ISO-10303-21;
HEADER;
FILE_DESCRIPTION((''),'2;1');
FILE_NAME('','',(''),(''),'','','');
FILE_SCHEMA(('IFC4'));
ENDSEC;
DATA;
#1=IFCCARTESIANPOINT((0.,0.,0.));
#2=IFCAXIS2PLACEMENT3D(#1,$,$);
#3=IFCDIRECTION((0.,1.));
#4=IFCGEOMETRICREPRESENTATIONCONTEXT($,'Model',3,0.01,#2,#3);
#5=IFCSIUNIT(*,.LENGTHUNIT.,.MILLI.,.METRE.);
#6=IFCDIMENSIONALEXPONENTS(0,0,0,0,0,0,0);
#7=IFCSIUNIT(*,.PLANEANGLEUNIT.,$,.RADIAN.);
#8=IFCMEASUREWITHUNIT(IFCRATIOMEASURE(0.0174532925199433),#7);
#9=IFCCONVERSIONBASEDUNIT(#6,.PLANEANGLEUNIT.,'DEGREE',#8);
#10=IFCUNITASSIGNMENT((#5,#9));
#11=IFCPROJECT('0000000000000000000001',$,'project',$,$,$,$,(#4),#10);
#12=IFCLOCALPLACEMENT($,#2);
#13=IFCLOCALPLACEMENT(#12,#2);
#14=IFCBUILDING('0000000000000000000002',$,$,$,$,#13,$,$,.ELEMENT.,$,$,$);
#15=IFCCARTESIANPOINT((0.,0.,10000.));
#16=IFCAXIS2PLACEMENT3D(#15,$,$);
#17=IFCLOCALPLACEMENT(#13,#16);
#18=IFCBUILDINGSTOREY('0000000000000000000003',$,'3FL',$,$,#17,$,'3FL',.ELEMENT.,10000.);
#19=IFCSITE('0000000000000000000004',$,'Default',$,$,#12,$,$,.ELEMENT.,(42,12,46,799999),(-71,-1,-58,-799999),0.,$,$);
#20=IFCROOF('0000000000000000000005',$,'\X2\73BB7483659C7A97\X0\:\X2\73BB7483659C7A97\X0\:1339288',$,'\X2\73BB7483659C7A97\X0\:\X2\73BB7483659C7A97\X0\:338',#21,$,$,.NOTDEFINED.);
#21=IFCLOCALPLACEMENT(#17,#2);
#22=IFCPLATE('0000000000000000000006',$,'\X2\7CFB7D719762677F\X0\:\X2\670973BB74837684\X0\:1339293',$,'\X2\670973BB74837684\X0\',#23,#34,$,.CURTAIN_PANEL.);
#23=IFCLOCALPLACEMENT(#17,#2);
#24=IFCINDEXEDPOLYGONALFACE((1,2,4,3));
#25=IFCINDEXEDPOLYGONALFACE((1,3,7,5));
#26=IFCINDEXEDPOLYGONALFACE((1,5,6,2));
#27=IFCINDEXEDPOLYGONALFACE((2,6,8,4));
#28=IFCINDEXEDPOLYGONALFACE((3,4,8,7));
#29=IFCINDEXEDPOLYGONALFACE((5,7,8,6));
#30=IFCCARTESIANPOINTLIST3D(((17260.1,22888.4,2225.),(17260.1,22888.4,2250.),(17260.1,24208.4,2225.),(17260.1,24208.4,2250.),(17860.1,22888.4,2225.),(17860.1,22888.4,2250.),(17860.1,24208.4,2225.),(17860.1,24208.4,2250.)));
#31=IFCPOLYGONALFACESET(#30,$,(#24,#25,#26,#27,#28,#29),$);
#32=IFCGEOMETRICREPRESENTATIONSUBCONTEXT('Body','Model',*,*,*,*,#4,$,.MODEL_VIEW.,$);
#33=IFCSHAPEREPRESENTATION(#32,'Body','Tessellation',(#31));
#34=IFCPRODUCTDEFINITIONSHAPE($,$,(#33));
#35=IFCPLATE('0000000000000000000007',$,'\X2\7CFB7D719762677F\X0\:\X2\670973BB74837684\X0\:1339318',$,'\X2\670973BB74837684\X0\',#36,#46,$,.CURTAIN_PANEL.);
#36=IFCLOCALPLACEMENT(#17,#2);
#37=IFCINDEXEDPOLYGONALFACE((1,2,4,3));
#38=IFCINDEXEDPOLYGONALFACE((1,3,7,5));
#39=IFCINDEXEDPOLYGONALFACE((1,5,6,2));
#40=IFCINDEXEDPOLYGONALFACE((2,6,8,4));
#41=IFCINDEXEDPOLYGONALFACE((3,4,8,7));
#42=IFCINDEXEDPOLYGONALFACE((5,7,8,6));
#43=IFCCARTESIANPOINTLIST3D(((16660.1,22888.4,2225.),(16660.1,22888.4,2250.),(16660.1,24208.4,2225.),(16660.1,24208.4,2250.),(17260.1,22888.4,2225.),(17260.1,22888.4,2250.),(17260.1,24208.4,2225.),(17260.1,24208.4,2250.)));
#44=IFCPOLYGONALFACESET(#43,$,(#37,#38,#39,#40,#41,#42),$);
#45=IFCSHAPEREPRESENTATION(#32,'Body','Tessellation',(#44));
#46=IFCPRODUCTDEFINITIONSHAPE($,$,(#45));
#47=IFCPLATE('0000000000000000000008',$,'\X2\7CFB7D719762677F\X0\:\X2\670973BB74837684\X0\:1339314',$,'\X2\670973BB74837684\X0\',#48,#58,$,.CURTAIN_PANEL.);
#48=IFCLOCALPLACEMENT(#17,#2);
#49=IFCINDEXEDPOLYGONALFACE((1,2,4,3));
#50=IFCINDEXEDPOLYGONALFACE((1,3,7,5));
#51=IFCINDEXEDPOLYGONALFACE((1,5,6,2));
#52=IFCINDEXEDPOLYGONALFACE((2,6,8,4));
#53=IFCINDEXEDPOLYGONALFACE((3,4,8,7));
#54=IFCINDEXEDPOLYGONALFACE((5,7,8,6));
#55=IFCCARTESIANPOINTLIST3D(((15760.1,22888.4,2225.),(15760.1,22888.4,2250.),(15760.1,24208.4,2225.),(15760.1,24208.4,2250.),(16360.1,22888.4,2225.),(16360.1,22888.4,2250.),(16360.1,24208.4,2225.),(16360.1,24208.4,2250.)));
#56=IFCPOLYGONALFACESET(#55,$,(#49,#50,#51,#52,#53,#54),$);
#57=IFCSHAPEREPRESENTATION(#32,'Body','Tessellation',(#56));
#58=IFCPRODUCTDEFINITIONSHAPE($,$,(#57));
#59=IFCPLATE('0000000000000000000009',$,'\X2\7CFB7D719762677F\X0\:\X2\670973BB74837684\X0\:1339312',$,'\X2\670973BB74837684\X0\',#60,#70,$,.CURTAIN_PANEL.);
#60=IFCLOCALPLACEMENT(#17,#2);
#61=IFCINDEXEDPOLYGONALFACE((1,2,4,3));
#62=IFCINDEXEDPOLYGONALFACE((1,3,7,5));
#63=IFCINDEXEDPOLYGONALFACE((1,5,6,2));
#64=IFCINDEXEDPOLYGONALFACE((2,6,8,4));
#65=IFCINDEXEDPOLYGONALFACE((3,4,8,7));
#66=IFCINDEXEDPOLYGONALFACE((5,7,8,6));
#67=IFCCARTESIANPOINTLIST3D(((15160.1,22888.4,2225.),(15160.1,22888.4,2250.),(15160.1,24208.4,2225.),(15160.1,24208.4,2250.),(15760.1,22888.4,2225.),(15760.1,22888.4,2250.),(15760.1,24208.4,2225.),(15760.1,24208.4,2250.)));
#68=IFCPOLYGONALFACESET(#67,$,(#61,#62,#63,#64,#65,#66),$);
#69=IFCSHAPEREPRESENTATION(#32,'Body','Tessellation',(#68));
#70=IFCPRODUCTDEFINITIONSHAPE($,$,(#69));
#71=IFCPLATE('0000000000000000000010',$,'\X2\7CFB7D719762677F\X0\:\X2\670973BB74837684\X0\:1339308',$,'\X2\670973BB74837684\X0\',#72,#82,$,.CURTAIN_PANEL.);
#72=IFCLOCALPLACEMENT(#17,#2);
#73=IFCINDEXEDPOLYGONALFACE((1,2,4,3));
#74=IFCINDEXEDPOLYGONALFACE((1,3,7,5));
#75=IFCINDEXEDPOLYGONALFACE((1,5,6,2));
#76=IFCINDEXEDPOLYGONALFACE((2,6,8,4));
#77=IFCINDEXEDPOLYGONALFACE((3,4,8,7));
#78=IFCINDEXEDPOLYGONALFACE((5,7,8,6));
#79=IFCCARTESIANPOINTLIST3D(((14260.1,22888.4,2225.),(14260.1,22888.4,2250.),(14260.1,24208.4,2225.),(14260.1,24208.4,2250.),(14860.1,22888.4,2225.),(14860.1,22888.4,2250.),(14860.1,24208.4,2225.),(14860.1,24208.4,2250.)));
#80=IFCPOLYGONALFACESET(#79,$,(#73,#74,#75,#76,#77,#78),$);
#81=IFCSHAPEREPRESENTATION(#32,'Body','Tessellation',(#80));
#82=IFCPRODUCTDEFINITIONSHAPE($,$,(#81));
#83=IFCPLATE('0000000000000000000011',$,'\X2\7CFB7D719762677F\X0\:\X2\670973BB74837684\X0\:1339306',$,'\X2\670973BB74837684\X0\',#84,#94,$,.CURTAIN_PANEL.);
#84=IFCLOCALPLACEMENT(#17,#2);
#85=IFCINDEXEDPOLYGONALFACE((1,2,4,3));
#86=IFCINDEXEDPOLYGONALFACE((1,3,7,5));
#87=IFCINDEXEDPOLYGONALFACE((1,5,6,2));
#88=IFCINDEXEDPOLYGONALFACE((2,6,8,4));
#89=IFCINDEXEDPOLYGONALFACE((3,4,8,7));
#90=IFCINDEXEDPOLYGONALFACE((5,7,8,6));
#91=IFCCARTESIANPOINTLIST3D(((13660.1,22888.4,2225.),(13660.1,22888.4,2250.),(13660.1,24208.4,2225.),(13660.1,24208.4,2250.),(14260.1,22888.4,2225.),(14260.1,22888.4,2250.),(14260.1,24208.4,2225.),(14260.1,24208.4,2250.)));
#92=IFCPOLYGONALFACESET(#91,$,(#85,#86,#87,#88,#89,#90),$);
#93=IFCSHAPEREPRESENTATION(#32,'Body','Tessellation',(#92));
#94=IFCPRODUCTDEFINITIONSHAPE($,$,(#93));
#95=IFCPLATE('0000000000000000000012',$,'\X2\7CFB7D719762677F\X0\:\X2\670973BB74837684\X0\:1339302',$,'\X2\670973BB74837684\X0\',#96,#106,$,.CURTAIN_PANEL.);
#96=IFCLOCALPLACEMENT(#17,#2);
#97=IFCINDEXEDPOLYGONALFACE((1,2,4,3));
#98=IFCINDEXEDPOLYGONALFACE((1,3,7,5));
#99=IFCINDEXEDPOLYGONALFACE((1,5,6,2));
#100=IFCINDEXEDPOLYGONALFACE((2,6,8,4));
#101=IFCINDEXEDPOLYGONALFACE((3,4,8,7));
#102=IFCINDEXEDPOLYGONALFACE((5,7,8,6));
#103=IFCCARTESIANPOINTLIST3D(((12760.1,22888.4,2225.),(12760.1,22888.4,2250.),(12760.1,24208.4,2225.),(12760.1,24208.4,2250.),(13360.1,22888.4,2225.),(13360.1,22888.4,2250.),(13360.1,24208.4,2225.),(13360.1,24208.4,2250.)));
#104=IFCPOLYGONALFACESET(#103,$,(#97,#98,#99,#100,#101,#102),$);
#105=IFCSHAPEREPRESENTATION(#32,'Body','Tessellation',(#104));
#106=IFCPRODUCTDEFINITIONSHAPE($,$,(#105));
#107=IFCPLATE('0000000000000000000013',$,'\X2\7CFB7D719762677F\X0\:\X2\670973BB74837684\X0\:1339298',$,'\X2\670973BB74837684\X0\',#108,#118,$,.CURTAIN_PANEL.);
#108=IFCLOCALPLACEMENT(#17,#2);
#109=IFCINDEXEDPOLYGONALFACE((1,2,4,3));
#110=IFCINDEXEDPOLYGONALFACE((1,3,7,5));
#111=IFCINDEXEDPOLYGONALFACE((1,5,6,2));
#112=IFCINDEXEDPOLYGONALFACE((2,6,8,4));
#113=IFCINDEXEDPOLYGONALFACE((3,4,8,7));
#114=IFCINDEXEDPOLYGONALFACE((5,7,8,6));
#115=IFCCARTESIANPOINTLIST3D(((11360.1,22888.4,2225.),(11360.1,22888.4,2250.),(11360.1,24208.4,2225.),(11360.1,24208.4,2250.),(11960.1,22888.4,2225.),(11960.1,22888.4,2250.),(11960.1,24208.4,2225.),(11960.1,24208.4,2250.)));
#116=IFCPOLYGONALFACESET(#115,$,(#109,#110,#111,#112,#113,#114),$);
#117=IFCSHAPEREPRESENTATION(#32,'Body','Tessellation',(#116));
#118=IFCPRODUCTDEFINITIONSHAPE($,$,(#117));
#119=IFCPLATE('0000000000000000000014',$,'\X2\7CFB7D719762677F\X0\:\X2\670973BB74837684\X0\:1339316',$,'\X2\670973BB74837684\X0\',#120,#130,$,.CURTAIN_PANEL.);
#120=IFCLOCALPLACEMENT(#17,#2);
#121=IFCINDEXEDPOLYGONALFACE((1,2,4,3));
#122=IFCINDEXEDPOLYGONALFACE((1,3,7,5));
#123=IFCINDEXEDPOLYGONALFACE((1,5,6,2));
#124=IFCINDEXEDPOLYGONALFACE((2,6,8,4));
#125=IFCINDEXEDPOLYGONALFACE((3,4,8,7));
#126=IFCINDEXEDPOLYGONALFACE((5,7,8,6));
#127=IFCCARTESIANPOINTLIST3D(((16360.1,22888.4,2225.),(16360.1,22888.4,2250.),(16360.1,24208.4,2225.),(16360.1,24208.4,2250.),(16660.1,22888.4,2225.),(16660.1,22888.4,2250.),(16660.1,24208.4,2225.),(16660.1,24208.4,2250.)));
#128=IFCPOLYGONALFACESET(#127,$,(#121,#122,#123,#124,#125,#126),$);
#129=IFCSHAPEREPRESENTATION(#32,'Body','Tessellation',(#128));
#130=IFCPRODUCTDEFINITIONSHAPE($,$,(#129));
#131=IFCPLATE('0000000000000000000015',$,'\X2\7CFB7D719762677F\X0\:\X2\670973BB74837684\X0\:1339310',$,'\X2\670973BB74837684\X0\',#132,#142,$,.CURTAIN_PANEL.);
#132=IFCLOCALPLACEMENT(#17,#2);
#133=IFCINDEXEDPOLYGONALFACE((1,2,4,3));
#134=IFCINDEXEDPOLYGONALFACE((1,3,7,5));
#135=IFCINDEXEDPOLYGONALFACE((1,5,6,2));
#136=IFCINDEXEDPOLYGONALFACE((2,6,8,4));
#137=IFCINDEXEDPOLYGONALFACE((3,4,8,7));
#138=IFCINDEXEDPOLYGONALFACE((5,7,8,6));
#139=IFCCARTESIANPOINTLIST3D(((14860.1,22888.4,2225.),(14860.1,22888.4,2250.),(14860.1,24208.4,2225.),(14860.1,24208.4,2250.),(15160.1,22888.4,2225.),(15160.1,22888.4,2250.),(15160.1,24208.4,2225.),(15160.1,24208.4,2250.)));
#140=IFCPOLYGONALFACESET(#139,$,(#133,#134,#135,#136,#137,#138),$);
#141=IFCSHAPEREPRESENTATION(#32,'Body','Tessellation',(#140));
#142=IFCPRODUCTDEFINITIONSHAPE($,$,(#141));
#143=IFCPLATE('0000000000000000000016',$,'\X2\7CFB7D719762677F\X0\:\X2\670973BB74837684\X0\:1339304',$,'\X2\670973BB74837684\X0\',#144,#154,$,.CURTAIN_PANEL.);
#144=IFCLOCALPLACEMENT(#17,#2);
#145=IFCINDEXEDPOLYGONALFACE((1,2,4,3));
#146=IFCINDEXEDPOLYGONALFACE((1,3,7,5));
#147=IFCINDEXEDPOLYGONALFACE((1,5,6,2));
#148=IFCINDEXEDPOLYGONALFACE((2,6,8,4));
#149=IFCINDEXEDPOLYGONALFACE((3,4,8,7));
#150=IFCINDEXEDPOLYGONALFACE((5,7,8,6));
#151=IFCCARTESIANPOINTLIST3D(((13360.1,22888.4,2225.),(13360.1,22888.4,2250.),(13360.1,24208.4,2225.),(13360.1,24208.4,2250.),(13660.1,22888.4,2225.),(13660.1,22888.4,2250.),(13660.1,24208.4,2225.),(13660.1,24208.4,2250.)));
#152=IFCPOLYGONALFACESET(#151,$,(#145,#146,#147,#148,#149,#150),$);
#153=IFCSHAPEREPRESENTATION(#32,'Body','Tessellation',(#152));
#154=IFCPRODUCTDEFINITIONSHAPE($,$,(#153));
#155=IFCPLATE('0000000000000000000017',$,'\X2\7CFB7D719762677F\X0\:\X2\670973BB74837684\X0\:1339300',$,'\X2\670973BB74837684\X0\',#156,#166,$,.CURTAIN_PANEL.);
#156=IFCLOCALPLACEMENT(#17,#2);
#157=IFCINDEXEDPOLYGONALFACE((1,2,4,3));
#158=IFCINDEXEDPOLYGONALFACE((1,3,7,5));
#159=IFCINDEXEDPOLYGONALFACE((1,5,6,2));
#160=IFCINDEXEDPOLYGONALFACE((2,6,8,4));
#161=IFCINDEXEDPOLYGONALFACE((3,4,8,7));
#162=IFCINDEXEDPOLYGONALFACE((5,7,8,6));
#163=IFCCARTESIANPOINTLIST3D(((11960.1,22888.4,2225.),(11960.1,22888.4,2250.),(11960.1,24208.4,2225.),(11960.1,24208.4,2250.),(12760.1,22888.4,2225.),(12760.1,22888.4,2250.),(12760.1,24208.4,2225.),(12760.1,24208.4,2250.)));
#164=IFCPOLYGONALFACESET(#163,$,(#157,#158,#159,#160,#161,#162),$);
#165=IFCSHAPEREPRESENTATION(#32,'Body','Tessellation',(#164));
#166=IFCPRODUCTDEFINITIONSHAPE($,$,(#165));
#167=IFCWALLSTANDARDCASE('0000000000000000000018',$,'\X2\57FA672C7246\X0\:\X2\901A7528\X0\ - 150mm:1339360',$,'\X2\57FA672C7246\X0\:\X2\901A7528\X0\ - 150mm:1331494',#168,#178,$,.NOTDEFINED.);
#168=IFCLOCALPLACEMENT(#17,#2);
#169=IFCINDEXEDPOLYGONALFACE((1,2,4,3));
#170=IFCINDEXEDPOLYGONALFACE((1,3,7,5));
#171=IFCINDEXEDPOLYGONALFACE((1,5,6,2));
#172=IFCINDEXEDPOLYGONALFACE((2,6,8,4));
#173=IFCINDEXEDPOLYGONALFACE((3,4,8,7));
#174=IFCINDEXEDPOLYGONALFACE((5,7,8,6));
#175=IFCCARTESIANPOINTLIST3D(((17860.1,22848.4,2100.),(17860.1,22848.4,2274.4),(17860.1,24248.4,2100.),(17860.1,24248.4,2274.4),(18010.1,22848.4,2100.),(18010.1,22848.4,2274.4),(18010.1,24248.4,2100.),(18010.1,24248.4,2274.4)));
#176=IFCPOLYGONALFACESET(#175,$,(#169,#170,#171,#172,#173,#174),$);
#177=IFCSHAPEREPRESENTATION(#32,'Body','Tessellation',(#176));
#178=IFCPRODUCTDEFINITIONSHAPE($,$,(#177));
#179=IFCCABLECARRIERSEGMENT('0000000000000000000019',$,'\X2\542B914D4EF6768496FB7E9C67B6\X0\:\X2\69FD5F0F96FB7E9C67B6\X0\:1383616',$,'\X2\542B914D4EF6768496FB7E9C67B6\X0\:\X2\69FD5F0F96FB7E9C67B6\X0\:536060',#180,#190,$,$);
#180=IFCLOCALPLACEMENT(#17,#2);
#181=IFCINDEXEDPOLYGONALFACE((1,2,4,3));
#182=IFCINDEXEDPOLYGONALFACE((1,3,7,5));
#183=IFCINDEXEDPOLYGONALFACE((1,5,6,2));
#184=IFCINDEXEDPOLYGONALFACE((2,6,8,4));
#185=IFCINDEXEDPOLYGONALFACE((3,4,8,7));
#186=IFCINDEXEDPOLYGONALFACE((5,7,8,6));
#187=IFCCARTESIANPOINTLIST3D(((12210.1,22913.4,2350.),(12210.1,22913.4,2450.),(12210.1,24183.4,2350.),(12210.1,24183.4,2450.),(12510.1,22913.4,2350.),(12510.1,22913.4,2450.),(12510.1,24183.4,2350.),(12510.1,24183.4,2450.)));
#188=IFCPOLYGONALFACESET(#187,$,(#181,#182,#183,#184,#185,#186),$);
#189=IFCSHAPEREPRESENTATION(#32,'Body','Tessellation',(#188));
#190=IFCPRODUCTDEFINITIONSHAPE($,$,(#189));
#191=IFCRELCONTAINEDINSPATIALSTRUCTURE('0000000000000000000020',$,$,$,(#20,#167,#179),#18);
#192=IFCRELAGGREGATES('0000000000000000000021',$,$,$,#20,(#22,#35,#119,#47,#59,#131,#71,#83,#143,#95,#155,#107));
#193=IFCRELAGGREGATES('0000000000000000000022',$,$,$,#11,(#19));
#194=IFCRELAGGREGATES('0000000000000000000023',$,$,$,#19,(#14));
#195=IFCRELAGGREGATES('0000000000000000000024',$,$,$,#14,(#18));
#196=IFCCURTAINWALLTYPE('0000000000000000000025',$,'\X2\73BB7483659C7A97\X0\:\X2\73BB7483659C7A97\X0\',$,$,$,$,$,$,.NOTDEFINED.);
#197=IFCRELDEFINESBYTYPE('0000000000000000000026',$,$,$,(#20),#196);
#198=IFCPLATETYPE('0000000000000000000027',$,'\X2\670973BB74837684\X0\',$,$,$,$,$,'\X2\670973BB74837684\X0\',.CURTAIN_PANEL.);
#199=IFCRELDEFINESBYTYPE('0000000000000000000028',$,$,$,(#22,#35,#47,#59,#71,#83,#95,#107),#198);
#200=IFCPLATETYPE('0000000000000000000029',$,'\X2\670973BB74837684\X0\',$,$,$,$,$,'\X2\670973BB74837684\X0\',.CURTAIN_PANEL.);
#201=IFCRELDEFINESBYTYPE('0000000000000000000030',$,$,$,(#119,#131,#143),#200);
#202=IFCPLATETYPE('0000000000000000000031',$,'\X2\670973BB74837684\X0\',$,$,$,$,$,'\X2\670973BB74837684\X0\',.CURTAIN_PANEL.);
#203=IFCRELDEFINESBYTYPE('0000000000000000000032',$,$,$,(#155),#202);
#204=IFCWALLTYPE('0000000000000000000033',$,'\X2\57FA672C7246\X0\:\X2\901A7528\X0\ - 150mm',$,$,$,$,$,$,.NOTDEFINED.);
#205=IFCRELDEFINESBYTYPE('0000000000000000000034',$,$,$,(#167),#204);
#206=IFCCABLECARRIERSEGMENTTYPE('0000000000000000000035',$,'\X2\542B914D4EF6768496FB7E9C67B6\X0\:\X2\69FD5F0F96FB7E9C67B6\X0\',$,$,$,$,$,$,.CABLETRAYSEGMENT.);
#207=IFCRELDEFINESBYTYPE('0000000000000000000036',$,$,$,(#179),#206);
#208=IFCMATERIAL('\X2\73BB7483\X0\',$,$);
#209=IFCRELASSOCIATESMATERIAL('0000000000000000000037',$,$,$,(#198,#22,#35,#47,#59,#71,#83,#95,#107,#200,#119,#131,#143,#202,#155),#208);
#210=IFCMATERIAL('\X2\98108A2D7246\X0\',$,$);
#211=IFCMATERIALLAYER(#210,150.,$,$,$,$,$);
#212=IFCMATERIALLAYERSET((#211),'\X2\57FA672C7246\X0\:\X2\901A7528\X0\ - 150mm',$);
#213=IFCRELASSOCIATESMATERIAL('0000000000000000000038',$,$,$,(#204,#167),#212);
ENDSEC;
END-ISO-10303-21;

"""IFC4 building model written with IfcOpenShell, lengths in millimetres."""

from ifc_helpers import new_model, entity, si_unit, converted_unit, direction, frame, frame_2d, origin, origin_2d_with_axis, place, context, subcontext, project, spatial, rectangle, extrude, source, transform, mapped, material, layer, layer_set, layer_usage, type_object, type_shapes, element, aggregate, save


model = new_model("IFC4")

# Units and contexts
model_context = context("Model", 3, precision=0.01, world=origin(), true_north=direction((0.0, 1.0)))
body_context = subcontext(model_context, "Body", "Model", "MODEL_VIEW")
ifc_project = project(units=[si_unit("LENGTHUNIT", "METRE", prefix="MILLI"), converted_unit("PLANEANGLEUNIT", "DEGREE", entity("IfcRatioMeasure", 0.0174532925199433), si_unit("PLANEANGLEUNIT", "RADIAN"), dimensions=[0, 0, 0, 0, 0, 0, 0])], contexts=[model_context])

# Site, building, storey
site_placement = place(None, origin())
site = spatial("IfcSite", under=ifc_project, at=site_placement, Name="Default", CompositionType="ELEMENT", RefLatitude=(42, 12, 46, 799999), RefLongitude=(-71, -1, -58, -799999), RefElevation=0.0)
building_placement = place(site_placement, origin())
building = spatial("IfcBuilding", under=site, at=building_placement, CompositionType="ELEMENT")
storey_placement = place(building_placement, frame((0.0, 0.0, 10000.0)))
storey = spatial("IfcBuildingStorey", under=building, at=storey_placement, Name="3FL", LongName="3FL", CompositionType="ELEMENT", Elevation=10000.0)

# Roof, plates
curtain_wall_type = type_object("IfcCurtainWallType", Name="玻璃斜窗:玻璃斜窗", PredefinedType="NOTDEFINED")
roof_placement = place(storey_placement, frame((0.0, 0.0, -10000.0)))
roof = element("IfcRoof", 1, at=roof_placement, inside=storey, type_object=curtain_wall_type, Name="玻璃斜窗:玻璃斜窗:1339288", ObjectType="玻璃斜窗:玻璃斜窗:338", PredefinedType="NOTDEFINED")
ifc_material_1 = material(Name="玻璃")
plate_type_1 = type_object("IfcPlateType", Name="有玻璃的", ElementType="有玻璃的", PredefinedType="CURTAIN_PANEL", material=ifc_material_1)
shared_shape_1 = source(origin(), body_context, "Body", "SweptSolid", [
    extrude(rectangle(XDim=25.0, YDim=600.0, at=origin_2d_with_axis()), frame((300.0, 12.5, 0.0), z_axis=(0.0, 0.0, 1.0), x_axis=(0.0, 1.0, 0.0)), (0.0, 0.0, 1.0), 1320.0),
])
type_shapes(plate_type_1, [shared_shape_1])
plate_1_placement = place(roof_placement, frame((17860.1, 24208.4, 12250.0), z_axis=(0.0, -1.0, 0.0), x_axis=(-1.0, 0.0, 0.0)))
plate_1 = element("IfcPlate", 2, at=plate_1_placement, type_object=plate_type_1, material=ifc_material_1, Name="系統面板:有玻璃的:1339293", ObjectType="有玻璃的", PredefinedType="CURTAIN_PANEL", context=body_context, shape_type="MappedRepresentation", body=[
    mapped(shared_shape_1, transform((0.0, 0.0, 0.0), scale=1.0)),
])
plate_2_placement = place(roof_placement, frame((17260.1, 24208.4, 12250.0), z_axis=(0.0, -1.0, 0.0), x_axis=(-1.0, 0.0, 0.0)))
plate_2 = element("IfcPlate", 3, at=plate_2_placement, type_object=plate_type_1, material=ifc_material_1, Name="系統面板:有玻璃的:1339318", ObjectType="有玻璃的", PredefinedType="CURTAIN_PANEL", context=body_context, shape_type="MappedRepresentation", body=[
    mapped(shared_shape_1, transform((0.0, 0.0, 0.0), scale=1.0)),
])
plate_3_placement = place(roof_placement, frame((16360.1, 24208.4, 12250.0), z_axis=(0.0, -1.0, 0.0), x_axis=(-1.0, 0.0, 0.0)))
plate_3 = element("IfcPlate", 4, at=plate_3_placement, type_object=plate_type_1, material=ifc_material_1, Name="系統面板:有玻璃的:1339314", ObjectType="有玻璃的", PredefinedType="CURTAIN_PANEL", context=body_context, shape_type="MappedRepresentation", body=[
    mapped(shared_shape_1, transform((0.0, 0.0, 0.0), scale=1.0)),
])
plate_4_placement = place(roof_placement, frame((15760.1, 24208.4, 12250.0), z_axis=(0.0, -1.0, 0.0), x_axis=(-1.0, 0.0, 0.0)))
plate_4 = element("IfcPlate", 5, at=plate_4_placement, type_object=plate_type_1, material=ifc_material_1, Name="系統面板:有玻璃的:1339312", ObjectType="有玻璃的", PredefinedType="CURTAIN_PANEL", context=body_context, shape_type="MappedRepresentation", body=[
    mapped(shared_shape_1, transform((0.0, 0.0, 0.0), scale=1.0)),
])
plate_5_placement = place(roof_placement, frame((14860.1, 24208.4, 12250.0), z_axis=(0.0, -1.0, 0.0), x_axis=(-1.0, 0.0, 0.0)))
plate_5 = element("IfcPlate", 6, at=plate_5_placement, type_object=plate_type_1, material=ifc_material_1, Name="系統面板:有玻璃的:1339308", ObjectType="有玻璃的", PredefinedType="CURTAIN_PANEL", context=body_context, shape_type="MappedRepresentation", body=[
    mapped(shared_shape_1, transform((0.0, 0.0, 0.0), scale=1.0)),
])
plate_6_placement = place(roof_placement, frame((14260.1, 24208.4, 12250.0), z_axis=(0.0, -1.0, 0.0), x_axis=(-1.0, 0.0, 0.0)))
plate_6 = element("IfcPlate", 7, at=plate_6_placement, type_object=plate_type_1, material=ifc_material_1, Name="系統面板:有玻璃的:1339306", ObjectType="有玻璃的", PredefinedType="CURTAIN_PANEL", context=body_context, shape_type="MappedRepresentation", body=[
    mapped(shared_shape_1, transform((0.0, 0.0, 0.0), scale=1.0)),
])
plate_7_placement = place(roof_placement, frame((13360.1, 24208.4, 12250.0), z_axis=(0.0, -1.0, 0.0), x_axis=(-1.0, 0.0, 0.0)))
plate_7 = element("IfcPlate", 8, at=plate_7_placement, type_object=plate_type_1, material=ifc_material_1, Name="系統面板:有玻璃的:1339302", ObjectType="有玻璃的", PredefinedType="CURTAIN_PANEL", context=body_context, shape_type="MappedRepresentation", body=[
    mapped(shared_shape_1, transform((0.0, 0.0, 0.0), scale=1.0)),
])
plate_8_placement = place(roof_placement, frame((11960.1, 24208.4, 12250.0), z_axis=(0.0, -1.0, 0.0), x_axis=(-1.0, 0.0, 0.0)))
plate_8 = element("IfcPlate", 9, at=plate_8_placement, type_object=plate_type_1, material=ifc_material_1, Name="系統面板:有玻璃的:1339298", ObjectType="有玻璃的", PredefinedType="CURTAIN_PANEL", context=body_context, shape_type="MappedRepresentation", body=[
    mapped(shared_shape_1, transform((0.0, 0.0, 0.0), scale=1.0)),
])
plate_type_2 = type_object("IfcPlateType", Name="有玻璃的", ElementType="有玻璃的", PredefinedType="CURTAIN_PANEL", material=ifc_material_1)
shared_shape_2 = source(origin(), body_context, "Body", "SweptSolid", [
    extrude(rectangle(XDim=25.0, YDim=300.0, at=origin_2d_with_axis()), frame((150.0, 12.5, 0.0), z_axis=(0.0, 0.0, 1.0), x_axis=(0.0, 1.0, 0.0)), (0.0, 0.0, 1.0), 1320.0),
])
type_shapes(plate_type_2, [shared_shape_2])
plate_9_placement = place(roof_placement, frame((16660.1, 24208.4, 12250.0), z_axis=(0.0, -1.0, 0.0), x_axis=(-1.0, 0.0, 0.0)))
plate_9 = element("IfcPlate", 10, at=plate_9_placement, type_object=plate_type_2, material=ifc_material_1, Name="系統面板:有玻璃的:1339316", ObjectType="有玻璃的", PredefinedType="CURTAIN_PANEL", context=body_context, shape_type="MappedRepresentation", body=[
    mapped(shared_shape_2, transform((0.0, 0.0, 0.0), scale=1.0)),
])
plate_10_placement = place(roof_placement, frame((15160.1, 24208.4, 12250.0), z_axis=(0.0, -1.0, 0.0), x_axis=(-1.0, 0.0, 0.0)))
plate_10 = element("IfcPlate", 11, at=plate_10_placement, type_object=plate_type_2, material=ifc_material_1, Name="系統面板:有玻璃的:1339310", ObjectType="有玻璃的", PredefinedType="CURTAIN_PANEL", context=body_context, shape_type="MappedRepresentation", body=[
    mapped(shared_shape_2, transform((0.0, 0.0, 0.0), scale=1.0)),
])
plate_11_placement = place(roof_placement, frame((13660.1, 24208.4, 12250.0), z_axis=(0.0, -1.0, 0.0), x_axis=(-1.0, 0.0, 0.0)))
plate_11 = element("IfcPlate", 12, at=plate_11_placement, type_object=plate_type_2, material=ifc_material_1, Name="系統面板:有玻璃的:1339304", ObjectType="有玻璃的", PredefinedType="CURTAIN_PANEL", context=body_context, shape_type="MappedRepresentation", body=[
    mapped(shared_shape_2, transform((0.0, 0.0, 0.0), scale=1.0)),
])
plate_type_3 = type_object("IfcPlateType", Name="有玻璃的", ElementType="有玻璃的", PredefinedType="CURTAIN_PANEL", material=ifc_material_1)
shared_shape_3 = source(origin(), body_context, "Body", "SweptSolid", [
    extrude(rectangle(XDim=25.0, YDim=800.0, at=origin_2d_with_axis()), frame((400.0, 12.5, 0.0), z_axis=(0.0, 0.0, 1.0), x_axis=(0.0, 1.0, 0.0)), (0.0, 0.0, 1.0), 1320.0),
])
type_shapes(plate_type_3, [shared_shape_3])
plate_12_placement = place(roof_placement, frame((12760.1, 24208.4, 12250.0), z_axis=(0.0, -1.0, 0.0), x_axis=(-1.0, 0.0, 0.0)))
plate_12 = element("IfcPlate", 13, at=plate_12_placement, type_object=plate_type_3, material=ifc_material_1, Name="系統面板:有玻璃的:1339300", ObjectType="有玻璃的", PredefinedType="CURTAIN_PANEL", context=body_context, shape_type="MappedRepresentation", body=[
    mapped(shared_shape_3, transform((0.0, 0.0, 0.0), scale=1.0)),
])
aggregate(roof, [plate_1, plate_2, plate_9, plate_3, plate_4, plate_10, plate_5, plate_6, plate_11, plate_7, plate_12, plate_8])

# Wall, opening
ifc_material_2 = material(Name="預設牆")
ifc_layer = layer(ifc_material_2, 150.0)
ifc_layer_set = layer_set([ifc_layer], Name="基本牆:通用 - 150mm")
ifc_layer_usage = layer_usage(ifc_layer_set, "AXIS2", "POSITIVE", -75.0)
wall_type = type_object("IfcWallType", Name="基本牆:通用 - 150mm", PredefinedType="NOTDEFINED", material=ifc_layer_set)
wall_placement = place(storey_placement, frame((17935.1, 24248.4, 2100.0), z_axis=(0.0, 0.0, 1.0), x_axis=(0.0, -1.0, 0.0)))
wall = element("IfcWallStandardCase", 14, at=wall_placement, inside=storey, type_object=wall_type, material=ifc_layer_usage, Name="基本牆:通用 - 150mm:1339360", ObjectType="基本牆:通用 - 150mm:1331494", PredefinedType="NOTDEFINED", context=body_context, shape_type="SweptSolid", body=[
    extrude(rectangle(XDim=1400.0, YDim=150.0, at=frame_2d((700.0, 0.0), x_axis=(-1.0, 0.0))), origin(), (0.0, 0.0, 1.0), 174.4),
])
opening_placement = place(wall_placement, frame((0.0, -75.0, -2100.0)))
element("IfcOpeningElement", 15, at=opening_placement, cuts=wall, ObjectType="Opening", PredefinedType="OPENING", context=body_context, shape_type="SweptSolid", body=[
    extrude(rectangle(XDim=2100.0, YDim=1400.0, at=frame_2d((1050.0, 700.0), x_axis=(1.0, 0.0))), frame((0.0, 0.0, 0.0), z_axis=(0.0, 1.0, 0.0), x_axis=(0.0, 0.0, 1.0)), (0.0, 0.0, 1.0), 150.0),
])

# Cable carrier segment
cable_carrier_segment_type_1 = type_object("IfcCableCarrierSegmentType", Name="含配件的電纜架:槽式電纜架", PredefinedType="CABLETRAYSEGMENT")
cable_carrier_segment_1_placement = place(storey_placement, frame((12210.1, 22913.4, 2350.0)))
element("IfcCableCarrierSegment", 16, at=cable_carrier_segment_1_placement, inside=storey, type_object=cable_carrier_segment_type_1, Name="含配件的電纜架:槽式電纜架:1383616", ObjectType="含配件的電纜架:槽式電纜架:536060", context=body_context, shape_type="SweptSolid", body=[
    extrude(rectangle(XDim=1270.0, YDim=300.0, at=frame_2d((0.0, 0.0), x_axis=(1.0, 0.0))), frame((150.0, 635.0, 0.0), z_axis=(0.0, 0.0, 1.0), x_axis=(0.0, 1.0, 0.0)), (0.0, 0.0, 1.0), 100.0),
])

save(model, "model.ifc")
